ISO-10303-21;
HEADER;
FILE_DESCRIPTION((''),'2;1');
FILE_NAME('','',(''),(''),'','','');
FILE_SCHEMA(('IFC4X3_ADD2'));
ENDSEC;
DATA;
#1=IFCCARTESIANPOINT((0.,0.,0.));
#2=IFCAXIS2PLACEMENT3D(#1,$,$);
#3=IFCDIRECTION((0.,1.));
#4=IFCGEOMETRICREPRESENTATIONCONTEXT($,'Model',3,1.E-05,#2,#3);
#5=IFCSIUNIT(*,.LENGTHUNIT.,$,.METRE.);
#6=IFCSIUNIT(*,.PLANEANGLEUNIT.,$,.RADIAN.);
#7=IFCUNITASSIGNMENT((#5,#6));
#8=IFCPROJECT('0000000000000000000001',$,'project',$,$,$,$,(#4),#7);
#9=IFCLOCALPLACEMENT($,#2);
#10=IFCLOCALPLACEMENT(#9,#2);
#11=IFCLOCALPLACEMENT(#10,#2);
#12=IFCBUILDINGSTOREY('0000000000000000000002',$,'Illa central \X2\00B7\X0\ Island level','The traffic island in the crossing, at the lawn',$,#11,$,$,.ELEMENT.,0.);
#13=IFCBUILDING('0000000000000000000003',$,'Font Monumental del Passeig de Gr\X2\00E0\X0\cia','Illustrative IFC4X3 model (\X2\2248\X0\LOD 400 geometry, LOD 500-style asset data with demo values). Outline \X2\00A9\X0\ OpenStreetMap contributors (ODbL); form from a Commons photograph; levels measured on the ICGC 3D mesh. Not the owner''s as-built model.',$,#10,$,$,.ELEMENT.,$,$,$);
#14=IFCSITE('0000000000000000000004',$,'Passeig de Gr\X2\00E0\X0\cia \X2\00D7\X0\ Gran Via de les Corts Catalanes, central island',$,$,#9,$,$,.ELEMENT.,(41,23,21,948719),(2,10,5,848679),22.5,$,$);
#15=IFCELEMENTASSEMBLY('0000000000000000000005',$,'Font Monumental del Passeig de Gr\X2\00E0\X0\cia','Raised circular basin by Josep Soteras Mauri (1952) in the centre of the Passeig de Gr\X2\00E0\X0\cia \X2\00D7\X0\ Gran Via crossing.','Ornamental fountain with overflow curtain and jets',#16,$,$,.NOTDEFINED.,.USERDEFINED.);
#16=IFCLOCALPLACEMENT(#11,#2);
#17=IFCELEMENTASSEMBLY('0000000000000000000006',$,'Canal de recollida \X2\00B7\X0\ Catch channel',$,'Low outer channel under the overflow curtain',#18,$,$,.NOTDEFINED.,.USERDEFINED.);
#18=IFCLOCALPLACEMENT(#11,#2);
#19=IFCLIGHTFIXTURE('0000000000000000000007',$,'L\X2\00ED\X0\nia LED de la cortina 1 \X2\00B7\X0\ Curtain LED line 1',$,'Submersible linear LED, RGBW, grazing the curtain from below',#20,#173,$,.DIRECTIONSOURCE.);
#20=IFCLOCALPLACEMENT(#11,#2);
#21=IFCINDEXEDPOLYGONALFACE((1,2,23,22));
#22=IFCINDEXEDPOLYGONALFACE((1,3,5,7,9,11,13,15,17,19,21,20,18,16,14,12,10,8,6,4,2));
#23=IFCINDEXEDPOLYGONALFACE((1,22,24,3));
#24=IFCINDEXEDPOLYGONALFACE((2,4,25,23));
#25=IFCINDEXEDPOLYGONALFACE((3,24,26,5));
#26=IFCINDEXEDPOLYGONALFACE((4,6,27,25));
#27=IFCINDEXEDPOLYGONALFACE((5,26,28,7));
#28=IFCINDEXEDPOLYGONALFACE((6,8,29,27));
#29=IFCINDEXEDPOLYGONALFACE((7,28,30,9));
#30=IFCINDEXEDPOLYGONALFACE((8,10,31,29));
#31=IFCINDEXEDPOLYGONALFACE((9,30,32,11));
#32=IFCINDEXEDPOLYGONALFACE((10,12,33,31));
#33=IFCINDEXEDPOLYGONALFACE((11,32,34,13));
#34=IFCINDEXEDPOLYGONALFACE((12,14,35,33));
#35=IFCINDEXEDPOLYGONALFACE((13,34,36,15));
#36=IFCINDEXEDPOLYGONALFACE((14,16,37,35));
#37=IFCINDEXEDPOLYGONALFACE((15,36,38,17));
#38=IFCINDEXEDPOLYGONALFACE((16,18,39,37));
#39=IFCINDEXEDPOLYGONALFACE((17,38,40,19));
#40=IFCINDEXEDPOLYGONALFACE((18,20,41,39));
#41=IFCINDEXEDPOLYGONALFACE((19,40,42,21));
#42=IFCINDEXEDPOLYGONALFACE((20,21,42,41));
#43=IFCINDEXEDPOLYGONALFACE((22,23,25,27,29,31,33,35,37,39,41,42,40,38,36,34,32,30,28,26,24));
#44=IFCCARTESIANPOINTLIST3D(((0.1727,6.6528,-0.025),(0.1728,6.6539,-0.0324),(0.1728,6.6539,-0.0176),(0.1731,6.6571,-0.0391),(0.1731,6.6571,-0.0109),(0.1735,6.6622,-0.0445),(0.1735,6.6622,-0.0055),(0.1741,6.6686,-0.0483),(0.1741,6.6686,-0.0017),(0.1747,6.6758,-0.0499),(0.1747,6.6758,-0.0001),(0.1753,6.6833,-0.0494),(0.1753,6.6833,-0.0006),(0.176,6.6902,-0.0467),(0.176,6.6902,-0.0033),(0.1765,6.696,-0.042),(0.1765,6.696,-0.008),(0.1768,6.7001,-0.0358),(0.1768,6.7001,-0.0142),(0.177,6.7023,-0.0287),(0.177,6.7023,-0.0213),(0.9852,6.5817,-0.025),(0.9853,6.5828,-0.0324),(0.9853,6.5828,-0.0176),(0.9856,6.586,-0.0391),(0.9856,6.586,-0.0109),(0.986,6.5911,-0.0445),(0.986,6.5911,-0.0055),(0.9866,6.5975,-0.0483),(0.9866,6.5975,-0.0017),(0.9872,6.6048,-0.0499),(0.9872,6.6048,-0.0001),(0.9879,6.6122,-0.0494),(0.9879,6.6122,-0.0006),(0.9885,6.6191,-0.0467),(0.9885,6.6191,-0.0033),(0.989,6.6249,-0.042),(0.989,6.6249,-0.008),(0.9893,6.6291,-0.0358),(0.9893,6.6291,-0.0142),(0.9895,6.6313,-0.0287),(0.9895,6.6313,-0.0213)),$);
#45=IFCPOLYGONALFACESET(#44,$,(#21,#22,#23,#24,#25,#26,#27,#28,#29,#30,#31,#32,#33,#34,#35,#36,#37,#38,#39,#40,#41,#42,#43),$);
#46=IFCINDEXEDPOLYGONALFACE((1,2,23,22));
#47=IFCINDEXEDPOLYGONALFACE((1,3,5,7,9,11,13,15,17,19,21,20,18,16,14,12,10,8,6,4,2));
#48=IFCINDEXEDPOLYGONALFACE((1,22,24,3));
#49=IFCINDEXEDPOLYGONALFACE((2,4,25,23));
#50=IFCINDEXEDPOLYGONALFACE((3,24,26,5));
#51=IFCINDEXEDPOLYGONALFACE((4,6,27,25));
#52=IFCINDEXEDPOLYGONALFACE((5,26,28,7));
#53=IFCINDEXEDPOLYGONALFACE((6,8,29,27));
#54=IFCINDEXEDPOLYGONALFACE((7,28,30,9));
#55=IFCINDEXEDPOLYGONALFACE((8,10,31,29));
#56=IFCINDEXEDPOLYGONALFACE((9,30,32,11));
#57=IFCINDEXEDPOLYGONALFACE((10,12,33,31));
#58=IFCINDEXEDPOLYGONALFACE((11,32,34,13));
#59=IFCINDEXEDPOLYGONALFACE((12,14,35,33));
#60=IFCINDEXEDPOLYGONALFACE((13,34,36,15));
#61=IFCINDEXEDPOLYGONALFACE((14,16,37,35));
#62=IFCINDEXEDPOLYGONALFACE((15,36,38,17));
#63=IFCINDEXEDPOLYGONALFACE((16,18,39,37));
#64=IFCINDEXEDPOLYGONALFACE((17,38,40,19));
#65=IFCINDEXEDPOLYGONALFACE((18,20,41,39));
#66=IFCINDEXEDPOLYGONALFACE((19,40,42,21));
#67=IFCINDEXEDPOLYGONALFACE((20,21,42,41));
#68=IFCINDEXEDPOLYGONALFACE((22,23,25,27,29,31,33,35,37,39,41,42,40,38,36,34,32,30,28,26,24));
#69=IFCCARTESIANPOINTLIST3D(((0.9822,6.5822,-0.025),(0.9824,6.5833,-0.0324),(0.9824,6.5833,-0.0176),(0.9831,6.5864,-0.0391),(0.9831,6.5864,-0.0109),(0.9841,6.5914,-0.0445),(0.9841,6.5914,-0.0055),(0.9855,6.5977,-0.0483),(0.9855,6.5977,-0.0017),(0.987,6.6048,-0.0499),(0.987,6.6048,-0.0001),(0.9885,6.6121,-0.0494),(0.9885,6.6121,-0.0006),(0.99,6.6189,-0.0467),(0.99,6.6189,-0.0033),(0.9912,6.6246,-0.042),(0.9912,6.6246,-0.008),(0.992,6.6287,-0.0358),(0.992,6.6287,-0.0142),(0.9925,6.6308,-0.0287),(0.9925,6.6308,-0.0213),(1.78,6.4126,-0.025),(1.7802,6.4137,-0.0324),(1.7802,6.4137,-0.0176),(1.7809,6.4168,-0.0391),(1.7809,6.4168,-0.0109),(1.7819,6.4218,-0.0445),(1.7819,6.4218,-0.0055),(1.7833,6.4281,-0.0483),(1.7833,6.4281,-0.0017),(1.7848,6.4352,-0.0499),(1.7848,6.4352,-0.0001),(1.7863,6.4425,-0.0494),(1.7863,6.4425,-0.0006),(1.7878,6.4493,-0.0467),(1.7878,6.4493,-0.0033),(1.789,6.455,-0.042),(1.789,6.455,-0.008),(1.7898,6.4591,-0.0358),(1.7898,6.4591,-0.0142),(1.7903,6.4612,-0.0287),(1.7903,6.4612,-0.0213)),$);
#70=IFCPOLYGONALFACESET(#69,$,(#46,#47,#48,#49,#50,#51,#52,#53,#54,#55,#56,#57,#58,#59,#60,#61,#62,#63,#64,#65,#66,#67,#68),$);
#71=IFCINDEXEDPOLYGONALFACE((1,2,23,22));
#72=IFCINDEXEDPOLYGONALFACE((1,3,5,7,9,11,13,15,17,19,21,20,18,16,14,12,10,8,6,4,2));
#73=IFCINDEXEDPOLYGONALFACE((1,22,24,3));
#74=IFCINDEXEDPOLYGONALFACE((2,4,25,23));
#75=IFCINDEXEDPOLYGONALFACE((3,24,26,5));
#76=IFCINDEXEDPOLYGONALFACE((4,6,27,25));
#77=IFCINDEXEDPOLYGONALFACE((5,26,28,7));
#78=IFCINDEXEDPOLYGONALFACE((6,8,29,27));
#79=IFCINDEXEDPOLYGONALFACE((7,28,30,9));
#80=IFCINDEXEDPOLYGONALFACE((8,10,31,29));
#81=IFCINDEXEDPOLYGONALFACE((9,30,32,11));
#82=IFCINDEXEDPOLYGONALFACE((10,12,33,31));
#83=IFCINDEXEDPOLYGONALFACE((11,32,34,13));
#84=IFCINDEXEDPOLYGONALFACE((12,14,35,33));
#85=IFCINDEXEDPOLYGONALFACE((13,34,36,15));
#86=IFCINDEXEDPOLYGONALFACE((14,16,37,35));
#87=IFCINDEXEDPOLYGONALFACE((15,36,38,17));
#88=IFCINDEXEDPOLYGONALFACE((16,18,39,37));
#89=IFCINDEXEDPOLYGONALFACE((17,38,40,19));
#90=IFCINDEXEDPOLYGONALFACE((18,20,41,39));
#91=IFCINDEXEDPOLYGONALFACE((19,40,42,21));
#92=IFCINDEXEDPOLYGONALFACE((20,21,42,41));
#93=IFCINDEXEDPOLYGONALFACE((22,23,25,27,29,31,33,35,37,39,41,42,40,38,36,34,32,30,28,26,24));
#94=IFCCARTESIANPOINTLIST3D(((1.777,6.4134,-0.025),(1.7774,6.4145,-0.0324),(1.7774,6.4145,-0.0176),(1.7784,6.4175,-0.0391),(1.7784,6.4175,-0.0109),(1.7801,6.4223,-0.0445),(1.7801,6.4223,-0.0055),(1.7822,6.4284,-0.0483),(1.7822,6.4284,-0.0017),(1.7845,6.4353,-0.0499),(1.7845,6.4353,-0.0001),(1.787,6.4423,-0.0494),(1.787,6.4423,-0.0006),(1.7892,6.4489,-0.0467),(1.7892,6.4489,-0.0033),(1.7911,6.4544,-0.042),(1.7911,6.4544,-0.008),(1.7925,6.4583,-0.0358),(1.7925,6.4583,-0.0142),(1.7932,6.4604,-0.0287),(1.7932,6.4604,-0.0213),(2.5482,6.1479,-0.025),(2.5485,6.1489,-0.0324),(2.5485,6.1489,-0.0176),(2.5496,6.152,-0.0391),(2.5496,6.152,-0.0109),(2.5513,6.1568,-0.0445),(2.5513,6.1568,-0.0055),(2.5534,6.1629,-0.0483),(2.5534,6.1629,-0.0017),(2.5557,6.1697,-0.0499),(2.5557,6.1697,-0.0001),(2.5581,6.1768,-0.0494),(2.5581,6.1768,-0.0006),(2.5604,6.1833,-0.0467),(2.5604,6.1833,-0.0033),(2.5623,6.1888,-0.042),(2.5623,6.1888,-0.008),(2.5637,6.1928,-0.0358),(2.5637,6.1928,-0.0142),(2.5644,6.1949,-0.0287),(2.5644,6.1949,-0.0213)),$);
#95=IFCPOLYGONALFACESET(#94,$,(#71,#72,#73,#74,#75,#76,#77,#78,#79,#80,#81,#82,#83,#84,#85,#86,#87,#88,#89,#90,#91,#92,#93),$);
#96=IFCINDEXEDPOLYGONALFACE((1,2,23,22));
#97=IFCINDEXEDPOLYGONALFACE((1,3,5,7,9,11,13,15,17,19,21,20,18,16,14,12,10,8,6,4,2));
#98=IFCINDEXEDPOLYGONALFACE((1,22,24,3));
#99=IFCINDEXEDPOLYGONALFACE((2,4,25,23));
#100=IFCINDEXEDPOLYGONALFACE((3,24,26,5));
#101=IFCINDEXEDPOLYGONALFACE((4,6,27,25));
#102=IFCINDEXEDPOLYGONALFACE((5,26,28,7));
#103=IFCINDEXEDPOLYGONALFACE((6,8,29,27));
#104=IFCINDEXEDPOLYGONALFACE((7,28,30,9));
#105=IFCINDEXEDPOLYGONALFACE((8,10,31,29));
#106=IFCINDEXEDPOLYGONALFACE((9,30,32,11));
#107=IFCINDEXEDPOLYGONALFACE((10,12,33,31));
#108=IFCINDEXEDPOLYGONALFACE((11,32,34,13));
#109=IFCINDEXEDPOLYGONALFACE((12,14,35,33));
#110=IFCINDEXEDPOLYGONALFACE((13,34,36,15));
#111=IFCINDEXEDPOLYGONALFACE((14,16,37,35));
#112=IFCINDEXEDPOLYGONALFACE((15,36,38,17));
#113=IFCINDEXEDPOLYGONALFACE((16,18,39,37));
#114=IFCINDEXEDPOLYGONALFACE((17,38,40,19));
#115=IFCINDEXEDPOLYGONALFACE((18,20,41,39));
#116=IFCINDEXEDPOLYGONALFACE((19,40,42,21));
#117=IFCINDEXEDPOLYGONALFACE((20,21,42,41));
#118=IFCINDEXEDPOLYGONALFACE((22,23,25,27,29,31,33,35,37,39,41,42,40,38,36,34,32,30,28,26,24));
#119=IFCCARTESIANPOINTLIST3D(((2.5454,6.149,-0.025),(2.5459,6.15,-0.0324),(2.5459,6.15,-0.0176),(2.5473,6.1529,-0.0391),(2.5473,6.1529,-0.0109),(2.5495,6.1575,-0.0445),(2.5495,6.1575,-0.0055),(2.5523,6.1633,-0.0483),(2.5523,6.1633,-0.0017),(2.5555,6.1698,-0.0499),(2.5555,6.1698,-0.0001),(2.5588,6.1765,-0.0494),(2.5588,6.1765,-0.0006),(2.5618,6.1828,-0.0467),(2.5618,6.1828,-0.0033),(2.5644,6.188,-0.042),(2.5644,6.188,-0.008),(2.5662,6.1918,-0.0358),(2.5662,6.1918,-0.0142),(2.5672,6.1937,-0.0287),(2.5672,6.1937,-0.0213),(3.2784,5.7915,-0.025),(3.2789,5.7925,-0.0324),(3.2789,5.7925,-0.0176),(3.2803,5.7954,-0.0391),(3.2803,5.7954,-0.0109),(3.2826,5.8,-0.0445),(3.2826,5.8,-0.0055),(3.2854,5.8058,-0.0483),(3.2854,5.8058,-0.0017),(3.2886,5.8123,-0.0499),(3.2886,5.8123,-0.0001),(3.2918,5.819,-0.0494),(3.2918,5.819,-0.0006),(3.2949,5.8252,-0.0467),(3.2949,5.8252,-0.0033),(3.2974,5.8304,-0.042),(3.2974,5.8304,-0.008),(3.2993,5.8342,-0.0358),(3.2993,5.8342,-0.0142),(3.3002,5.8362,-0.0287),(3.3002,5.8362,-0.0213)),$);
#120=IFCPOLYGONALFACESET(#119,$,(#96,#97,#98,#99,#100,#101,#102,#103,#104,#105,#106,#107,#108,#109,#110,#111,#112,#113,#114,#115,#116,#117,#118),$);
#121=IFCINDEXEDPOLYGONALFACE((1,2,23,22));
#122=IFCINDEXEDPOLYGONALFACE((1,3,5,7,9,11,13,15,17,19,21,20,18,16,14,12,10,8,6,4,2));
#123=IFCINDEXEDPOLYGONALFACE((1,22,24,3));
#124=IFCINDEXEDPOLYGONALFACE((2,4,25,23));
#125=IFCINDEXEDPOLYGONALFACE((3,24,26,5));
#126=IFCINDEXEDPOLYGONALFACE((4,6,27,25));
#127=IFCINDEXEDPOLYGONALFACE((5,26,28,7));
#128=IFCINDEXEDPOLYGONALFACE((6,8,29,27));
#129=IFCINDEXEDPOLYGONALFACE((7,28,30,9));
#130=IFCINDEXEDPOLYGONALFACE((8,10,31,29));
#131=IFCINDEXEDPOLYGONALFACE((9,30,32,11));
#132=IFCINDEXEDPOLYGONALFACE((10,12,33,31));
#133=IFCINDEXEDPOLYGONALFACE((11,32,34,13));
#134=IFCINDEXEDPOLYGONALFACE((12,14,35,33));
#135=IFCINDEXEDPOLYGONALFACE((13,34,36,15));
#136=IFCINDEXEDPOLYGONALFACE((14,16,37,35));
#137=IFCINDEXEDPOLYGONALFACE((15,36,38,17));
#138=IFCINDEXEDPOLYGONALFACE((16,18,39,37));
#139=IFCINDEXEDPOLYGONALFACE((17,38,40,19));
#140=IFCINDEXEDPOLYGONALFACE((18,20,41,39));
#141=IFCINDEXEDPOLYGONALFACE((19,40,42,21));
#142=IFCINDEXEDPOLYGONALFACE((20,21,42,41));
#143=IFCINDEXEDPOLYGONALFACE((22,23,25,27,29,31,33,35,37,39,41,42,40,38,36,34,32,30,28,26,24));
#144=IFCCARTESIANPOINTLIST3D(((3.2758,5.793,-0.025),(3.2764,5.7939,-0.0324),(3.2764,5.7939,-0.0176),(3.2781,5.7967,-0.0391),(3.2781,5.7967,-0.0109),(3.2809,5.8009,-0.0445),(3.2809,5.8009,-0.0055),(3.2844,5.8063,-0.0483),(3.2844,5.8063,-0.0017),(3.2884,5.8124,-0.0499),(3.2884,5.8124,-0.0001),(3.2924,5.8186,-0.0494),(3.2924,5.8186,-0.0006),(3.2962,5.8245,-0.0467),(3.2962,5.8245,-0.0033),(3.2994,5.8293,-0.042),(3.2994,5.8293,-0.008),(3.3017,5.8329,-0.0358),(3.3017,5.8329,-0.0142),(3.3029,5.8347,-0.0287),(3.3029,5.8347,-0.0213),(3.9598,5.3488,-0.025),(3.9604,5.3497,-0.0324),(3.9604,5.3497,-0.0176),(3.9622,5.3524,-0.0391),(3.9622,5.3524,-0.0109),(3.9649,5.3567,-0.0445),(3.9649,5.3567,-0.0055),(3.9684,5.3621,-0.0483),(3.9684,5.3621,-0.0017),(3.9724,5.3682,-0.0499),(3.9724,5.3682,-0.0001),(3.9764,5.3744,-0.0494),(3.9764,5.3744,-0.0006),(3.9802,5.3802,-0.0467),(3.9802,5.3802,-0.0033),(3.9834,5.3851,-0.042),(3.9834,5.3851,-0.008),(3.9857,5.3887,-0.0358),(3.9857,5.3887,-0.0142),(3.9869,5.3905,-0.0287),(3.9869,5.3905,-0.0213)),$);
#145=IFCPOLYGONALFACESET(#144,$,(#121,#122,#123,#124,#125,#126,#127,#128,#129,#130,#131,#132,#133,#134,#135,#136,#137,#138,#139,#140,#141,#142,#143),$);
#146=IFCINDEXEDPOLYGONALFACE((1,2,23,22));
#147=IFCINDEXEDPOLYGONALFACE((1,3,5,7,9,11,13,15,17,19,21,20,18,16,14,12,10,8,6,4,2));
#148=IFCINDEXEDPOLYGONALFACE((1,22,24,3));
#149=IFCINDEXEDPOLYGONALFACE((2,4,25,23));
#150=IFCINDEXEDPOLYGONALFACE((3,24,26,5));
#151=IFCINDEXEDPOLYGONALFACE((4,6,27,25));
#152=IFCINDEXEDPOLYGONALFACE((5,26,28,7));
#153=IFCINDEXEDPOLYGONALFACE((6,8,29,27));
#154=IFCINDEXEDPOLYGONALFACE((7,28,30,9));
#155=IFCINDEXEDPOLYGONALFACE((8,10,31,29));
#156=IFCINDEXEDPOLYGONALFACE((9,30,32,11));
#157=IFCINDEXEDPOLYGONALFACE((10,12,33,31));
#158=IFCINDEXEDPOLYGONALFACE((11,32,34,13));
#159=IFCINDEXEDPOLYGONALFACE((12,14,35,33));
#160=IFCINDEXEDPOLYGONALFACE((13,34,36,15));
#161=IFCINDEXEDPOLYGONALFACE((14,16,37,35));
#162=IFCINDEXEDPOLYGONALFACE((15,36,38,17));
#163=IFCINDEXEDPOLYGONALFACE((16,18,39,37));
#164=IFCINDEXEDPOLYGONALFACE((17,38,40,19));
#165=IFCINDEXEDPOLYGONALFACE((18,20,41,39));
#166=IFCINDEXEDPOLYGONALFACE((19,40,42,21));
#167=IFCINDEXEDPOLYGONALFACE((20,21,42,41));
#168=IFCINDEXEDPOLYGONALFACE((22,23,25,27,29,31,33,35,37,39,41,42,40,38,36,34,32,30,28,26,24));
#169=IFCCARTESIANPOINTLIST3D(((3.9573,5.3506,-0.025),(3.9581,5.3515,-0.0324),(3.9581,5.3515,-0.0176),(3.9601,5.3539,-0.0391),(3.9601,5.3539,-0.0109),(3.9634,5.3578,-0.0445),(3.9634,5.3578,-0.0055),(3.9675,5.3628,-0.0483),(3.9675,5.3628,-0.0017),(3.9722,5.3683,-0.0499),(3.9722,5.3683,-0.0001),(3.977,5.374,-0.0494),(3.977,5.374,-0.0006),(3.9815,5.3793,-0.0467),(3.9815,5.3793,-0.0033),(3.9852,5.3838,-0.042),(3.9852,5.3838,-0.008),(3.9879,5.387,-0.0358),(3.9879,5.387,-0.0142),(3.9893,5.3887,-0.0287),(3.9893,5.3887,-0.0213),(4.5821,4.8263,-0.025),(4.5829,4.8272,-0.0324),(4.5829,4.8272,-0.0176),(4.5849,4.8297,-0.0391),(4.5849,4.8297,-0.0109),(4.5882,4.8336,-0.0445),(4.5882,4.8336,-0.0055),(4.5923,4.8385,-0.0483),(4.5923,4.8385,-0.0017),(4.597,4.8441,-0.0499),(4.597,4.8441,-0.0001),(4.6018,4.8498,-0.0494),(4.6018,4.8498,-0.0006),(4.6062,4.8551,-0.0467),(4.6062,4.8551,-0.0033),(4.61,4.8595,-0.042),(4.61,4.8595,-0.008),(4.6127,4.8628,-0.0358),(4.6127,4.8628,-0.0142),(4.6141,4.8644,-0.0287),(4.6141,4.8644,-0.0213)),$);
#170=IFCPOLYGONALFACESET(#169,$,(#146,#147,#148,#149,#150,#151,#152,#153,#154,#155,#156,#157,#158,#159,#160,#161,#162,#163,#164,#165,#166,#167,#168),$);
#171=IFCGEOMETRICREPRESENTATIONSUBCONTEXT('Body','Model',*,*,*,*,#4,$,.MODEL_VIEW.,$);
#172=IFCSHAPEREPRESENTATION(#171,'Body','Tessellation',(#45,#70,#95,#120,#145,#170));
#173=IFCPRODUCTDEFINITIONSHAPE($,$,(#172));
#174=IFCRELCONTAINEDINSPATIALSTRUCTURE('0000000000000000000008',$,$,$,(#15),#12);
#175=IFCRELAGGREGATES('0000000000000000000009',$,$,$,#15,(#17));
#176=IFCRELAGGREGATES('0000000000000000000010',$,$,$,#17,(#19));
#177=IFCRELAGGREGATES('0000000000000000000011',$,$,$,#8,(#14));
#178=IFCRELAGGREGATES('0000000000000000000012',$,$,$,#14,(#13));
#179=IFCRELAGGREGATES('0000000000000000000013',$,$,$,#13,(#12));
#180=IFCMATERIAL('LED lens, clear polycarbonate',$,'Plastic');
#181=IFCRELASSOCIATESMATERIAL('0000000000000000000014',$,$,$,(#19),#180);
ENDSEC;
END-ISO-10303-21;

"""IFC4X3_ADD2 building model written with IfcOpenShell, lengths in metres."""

from ifc_helpers import new_model, si_unit, direction, frame, origin, origin_2d_with_axis, place, context, subcontext, project, spatial, circle, extrude, material, element, aggregate, save


model = new_model("IFC4X3_ADD2")

# Units and contexts
model_context = context("Model", 3, precision=1e-05, world=origin(), true_north=direction((0.0, 1.0)))
body_context = subcontext(model_context, "Body", "Model", "MODEL_VIEW")
ifc_project = project(units=[si_unit("LENGTHUNIT", "METRE"), si_unit("PLANEANGLEUNIT", "RADIAN")], contexts=[model_context])

# Site, building, storey
site_placement = place(None, origin())
site = spatial("IfcSite", under=ifc_project, at=site_placement, Name="Passeig de Gràcia × Gran Via de les Corts Catalanes, central island", CompositionType="ELEMENT", RefLatitude=(41, 23, 21, 948719), RefLongitude=(2, 10, 5, 848679), RefElevation=22.5)
building_placement = place(site_placement, origin())
building = spatial("IfcBuilding", under=site, at=building_placement, Name="Font Monumental del Passeig de Gràcia", Description="Illustrative IFC4X3 model (≈LOD 400 geometry, LOD 500-style asset data with demo values). Outline © OpenStreetMap contributors (ODbL); form from a Commons photograph; levels measured on the ICGC 3D mesh. Not the owner's as-built model.", CompositionType="ELEMENT")
storey_placement = place(building_placement, origin())
storey = spatial("IfcBuildingStorey", under=building, at=storey_placement, Name="Illa central · Island level", Description="The traffic island in the crossing, at the lawn", CompositionType="ELEMENT", Elevation=0.0)

# Element assemblies, light fixture
assembly_1_placement = place(building_placement, origin())
assembly_1 = element("IfcElementAssembly", 1, at=assembly_1_placement, inside=storey, Name="Font Monumental del Passeig de Gràcia", Description="Raised circular basin by Josep Soteras Mauri (1952) in the centre of the Passeig de Gràcia × Gran Via crossing.", ObjectType="Ornamental fountain with overflow curtain and jets", AssemblyPlace="NOTDEFINED", PredefinedType="USERDEFINED")
assembly_2_placement = place(building_placement, origin())
assembly_2 = element("IfcElementAssembly", 2, at=assembly_2_placement, Name="Canal de recollida · Catch channel", ObjectType="Low outer channel under the overflow curtain", AssemblyPlace="NOTDEFINED", PredefinedType="USERDEFINED")
ifc_material_1 = material(Name="LED lens, clear polycarbonate", Category="Plastic")
light_fixture_1_placement = place(building_placement, origin())
light_fixture_1 = element("IfcLightFixture", 3, at=light_fixture_1_placement, material=ifc_material_1, Name="Línia LED de la cortina 1 · Curtain LED line 1", ObjectType="Submersible linear LED, RGBW, grazing the curtain from below", PredefinedType="DIRECTIONSOURCE", context=body_context, shape_type="SweptSolid", body=[
    extrude(circle(Radius=0.025, at=origin_2d_with_axis()), frame((0.1749, 6.6777, -0.025), z_axis=(0.996195, -0.087156, 0.0), x_axis=(-0.087156, -0.996195, 0.0)), (0.0, 0.0, 1.0), 0.8156),
    extrude(circle(Radius=0.025, at=origin_2d_with_axis()), frame((0.9874, 6.6066, -0.025), z_axis=(0.978148, -0.207912, 0.0), x_axis=(-0.207912, -0.978148, 0.0)), (0.0, 0.0, 1.0), 0.8156),
    extrude(circle(Radius=0.025, at=origin_2d_with_axis()), frame((1.7852, 6.4371, -0.025), z_axis=(0.945519, -0.325568, 0.0), x_axis=(-0.325568, -0.945519, 0.0)), (0.0, 0.0, 1.0), 0.8156),
    extrude(circle(Radius=0.025, at=origin_2d_with_axis()), frame((2.5563, 6.1715, -0.025), z_axis=(0.898794, -0.438371, 0.0), x_axis=(-0.438371, -0.898794, 0.0)), (0.0, 0.0, 1.0), 0.8156),
    extrude(circle(Radius=0.025, at=origin_2d_with_axis()), frame((3.2894, 5.814, -0.025), z_axis=(0.838671, -0.544639, 0.0), x_axis=(-0.544639, -0.838671, 0.0)), (0.0, 0.0, 1.0), 0.8156),
    extrude(circle(Radius=0.025, at=origin_2d_with_axis()), frame((3.9734, 5.3698, -0.025), z_axis=(0.766044, -0.642788, 0.0), x_axis=(-0.642788, -0.766044, 0.0)), (0.0, 0.0, 1.0), 0.8156),
])
aggregate(assembly_1, [assembly_2])
aggregate(assembly_2, [light_fixture_1])

save(model, "model.ifc")
